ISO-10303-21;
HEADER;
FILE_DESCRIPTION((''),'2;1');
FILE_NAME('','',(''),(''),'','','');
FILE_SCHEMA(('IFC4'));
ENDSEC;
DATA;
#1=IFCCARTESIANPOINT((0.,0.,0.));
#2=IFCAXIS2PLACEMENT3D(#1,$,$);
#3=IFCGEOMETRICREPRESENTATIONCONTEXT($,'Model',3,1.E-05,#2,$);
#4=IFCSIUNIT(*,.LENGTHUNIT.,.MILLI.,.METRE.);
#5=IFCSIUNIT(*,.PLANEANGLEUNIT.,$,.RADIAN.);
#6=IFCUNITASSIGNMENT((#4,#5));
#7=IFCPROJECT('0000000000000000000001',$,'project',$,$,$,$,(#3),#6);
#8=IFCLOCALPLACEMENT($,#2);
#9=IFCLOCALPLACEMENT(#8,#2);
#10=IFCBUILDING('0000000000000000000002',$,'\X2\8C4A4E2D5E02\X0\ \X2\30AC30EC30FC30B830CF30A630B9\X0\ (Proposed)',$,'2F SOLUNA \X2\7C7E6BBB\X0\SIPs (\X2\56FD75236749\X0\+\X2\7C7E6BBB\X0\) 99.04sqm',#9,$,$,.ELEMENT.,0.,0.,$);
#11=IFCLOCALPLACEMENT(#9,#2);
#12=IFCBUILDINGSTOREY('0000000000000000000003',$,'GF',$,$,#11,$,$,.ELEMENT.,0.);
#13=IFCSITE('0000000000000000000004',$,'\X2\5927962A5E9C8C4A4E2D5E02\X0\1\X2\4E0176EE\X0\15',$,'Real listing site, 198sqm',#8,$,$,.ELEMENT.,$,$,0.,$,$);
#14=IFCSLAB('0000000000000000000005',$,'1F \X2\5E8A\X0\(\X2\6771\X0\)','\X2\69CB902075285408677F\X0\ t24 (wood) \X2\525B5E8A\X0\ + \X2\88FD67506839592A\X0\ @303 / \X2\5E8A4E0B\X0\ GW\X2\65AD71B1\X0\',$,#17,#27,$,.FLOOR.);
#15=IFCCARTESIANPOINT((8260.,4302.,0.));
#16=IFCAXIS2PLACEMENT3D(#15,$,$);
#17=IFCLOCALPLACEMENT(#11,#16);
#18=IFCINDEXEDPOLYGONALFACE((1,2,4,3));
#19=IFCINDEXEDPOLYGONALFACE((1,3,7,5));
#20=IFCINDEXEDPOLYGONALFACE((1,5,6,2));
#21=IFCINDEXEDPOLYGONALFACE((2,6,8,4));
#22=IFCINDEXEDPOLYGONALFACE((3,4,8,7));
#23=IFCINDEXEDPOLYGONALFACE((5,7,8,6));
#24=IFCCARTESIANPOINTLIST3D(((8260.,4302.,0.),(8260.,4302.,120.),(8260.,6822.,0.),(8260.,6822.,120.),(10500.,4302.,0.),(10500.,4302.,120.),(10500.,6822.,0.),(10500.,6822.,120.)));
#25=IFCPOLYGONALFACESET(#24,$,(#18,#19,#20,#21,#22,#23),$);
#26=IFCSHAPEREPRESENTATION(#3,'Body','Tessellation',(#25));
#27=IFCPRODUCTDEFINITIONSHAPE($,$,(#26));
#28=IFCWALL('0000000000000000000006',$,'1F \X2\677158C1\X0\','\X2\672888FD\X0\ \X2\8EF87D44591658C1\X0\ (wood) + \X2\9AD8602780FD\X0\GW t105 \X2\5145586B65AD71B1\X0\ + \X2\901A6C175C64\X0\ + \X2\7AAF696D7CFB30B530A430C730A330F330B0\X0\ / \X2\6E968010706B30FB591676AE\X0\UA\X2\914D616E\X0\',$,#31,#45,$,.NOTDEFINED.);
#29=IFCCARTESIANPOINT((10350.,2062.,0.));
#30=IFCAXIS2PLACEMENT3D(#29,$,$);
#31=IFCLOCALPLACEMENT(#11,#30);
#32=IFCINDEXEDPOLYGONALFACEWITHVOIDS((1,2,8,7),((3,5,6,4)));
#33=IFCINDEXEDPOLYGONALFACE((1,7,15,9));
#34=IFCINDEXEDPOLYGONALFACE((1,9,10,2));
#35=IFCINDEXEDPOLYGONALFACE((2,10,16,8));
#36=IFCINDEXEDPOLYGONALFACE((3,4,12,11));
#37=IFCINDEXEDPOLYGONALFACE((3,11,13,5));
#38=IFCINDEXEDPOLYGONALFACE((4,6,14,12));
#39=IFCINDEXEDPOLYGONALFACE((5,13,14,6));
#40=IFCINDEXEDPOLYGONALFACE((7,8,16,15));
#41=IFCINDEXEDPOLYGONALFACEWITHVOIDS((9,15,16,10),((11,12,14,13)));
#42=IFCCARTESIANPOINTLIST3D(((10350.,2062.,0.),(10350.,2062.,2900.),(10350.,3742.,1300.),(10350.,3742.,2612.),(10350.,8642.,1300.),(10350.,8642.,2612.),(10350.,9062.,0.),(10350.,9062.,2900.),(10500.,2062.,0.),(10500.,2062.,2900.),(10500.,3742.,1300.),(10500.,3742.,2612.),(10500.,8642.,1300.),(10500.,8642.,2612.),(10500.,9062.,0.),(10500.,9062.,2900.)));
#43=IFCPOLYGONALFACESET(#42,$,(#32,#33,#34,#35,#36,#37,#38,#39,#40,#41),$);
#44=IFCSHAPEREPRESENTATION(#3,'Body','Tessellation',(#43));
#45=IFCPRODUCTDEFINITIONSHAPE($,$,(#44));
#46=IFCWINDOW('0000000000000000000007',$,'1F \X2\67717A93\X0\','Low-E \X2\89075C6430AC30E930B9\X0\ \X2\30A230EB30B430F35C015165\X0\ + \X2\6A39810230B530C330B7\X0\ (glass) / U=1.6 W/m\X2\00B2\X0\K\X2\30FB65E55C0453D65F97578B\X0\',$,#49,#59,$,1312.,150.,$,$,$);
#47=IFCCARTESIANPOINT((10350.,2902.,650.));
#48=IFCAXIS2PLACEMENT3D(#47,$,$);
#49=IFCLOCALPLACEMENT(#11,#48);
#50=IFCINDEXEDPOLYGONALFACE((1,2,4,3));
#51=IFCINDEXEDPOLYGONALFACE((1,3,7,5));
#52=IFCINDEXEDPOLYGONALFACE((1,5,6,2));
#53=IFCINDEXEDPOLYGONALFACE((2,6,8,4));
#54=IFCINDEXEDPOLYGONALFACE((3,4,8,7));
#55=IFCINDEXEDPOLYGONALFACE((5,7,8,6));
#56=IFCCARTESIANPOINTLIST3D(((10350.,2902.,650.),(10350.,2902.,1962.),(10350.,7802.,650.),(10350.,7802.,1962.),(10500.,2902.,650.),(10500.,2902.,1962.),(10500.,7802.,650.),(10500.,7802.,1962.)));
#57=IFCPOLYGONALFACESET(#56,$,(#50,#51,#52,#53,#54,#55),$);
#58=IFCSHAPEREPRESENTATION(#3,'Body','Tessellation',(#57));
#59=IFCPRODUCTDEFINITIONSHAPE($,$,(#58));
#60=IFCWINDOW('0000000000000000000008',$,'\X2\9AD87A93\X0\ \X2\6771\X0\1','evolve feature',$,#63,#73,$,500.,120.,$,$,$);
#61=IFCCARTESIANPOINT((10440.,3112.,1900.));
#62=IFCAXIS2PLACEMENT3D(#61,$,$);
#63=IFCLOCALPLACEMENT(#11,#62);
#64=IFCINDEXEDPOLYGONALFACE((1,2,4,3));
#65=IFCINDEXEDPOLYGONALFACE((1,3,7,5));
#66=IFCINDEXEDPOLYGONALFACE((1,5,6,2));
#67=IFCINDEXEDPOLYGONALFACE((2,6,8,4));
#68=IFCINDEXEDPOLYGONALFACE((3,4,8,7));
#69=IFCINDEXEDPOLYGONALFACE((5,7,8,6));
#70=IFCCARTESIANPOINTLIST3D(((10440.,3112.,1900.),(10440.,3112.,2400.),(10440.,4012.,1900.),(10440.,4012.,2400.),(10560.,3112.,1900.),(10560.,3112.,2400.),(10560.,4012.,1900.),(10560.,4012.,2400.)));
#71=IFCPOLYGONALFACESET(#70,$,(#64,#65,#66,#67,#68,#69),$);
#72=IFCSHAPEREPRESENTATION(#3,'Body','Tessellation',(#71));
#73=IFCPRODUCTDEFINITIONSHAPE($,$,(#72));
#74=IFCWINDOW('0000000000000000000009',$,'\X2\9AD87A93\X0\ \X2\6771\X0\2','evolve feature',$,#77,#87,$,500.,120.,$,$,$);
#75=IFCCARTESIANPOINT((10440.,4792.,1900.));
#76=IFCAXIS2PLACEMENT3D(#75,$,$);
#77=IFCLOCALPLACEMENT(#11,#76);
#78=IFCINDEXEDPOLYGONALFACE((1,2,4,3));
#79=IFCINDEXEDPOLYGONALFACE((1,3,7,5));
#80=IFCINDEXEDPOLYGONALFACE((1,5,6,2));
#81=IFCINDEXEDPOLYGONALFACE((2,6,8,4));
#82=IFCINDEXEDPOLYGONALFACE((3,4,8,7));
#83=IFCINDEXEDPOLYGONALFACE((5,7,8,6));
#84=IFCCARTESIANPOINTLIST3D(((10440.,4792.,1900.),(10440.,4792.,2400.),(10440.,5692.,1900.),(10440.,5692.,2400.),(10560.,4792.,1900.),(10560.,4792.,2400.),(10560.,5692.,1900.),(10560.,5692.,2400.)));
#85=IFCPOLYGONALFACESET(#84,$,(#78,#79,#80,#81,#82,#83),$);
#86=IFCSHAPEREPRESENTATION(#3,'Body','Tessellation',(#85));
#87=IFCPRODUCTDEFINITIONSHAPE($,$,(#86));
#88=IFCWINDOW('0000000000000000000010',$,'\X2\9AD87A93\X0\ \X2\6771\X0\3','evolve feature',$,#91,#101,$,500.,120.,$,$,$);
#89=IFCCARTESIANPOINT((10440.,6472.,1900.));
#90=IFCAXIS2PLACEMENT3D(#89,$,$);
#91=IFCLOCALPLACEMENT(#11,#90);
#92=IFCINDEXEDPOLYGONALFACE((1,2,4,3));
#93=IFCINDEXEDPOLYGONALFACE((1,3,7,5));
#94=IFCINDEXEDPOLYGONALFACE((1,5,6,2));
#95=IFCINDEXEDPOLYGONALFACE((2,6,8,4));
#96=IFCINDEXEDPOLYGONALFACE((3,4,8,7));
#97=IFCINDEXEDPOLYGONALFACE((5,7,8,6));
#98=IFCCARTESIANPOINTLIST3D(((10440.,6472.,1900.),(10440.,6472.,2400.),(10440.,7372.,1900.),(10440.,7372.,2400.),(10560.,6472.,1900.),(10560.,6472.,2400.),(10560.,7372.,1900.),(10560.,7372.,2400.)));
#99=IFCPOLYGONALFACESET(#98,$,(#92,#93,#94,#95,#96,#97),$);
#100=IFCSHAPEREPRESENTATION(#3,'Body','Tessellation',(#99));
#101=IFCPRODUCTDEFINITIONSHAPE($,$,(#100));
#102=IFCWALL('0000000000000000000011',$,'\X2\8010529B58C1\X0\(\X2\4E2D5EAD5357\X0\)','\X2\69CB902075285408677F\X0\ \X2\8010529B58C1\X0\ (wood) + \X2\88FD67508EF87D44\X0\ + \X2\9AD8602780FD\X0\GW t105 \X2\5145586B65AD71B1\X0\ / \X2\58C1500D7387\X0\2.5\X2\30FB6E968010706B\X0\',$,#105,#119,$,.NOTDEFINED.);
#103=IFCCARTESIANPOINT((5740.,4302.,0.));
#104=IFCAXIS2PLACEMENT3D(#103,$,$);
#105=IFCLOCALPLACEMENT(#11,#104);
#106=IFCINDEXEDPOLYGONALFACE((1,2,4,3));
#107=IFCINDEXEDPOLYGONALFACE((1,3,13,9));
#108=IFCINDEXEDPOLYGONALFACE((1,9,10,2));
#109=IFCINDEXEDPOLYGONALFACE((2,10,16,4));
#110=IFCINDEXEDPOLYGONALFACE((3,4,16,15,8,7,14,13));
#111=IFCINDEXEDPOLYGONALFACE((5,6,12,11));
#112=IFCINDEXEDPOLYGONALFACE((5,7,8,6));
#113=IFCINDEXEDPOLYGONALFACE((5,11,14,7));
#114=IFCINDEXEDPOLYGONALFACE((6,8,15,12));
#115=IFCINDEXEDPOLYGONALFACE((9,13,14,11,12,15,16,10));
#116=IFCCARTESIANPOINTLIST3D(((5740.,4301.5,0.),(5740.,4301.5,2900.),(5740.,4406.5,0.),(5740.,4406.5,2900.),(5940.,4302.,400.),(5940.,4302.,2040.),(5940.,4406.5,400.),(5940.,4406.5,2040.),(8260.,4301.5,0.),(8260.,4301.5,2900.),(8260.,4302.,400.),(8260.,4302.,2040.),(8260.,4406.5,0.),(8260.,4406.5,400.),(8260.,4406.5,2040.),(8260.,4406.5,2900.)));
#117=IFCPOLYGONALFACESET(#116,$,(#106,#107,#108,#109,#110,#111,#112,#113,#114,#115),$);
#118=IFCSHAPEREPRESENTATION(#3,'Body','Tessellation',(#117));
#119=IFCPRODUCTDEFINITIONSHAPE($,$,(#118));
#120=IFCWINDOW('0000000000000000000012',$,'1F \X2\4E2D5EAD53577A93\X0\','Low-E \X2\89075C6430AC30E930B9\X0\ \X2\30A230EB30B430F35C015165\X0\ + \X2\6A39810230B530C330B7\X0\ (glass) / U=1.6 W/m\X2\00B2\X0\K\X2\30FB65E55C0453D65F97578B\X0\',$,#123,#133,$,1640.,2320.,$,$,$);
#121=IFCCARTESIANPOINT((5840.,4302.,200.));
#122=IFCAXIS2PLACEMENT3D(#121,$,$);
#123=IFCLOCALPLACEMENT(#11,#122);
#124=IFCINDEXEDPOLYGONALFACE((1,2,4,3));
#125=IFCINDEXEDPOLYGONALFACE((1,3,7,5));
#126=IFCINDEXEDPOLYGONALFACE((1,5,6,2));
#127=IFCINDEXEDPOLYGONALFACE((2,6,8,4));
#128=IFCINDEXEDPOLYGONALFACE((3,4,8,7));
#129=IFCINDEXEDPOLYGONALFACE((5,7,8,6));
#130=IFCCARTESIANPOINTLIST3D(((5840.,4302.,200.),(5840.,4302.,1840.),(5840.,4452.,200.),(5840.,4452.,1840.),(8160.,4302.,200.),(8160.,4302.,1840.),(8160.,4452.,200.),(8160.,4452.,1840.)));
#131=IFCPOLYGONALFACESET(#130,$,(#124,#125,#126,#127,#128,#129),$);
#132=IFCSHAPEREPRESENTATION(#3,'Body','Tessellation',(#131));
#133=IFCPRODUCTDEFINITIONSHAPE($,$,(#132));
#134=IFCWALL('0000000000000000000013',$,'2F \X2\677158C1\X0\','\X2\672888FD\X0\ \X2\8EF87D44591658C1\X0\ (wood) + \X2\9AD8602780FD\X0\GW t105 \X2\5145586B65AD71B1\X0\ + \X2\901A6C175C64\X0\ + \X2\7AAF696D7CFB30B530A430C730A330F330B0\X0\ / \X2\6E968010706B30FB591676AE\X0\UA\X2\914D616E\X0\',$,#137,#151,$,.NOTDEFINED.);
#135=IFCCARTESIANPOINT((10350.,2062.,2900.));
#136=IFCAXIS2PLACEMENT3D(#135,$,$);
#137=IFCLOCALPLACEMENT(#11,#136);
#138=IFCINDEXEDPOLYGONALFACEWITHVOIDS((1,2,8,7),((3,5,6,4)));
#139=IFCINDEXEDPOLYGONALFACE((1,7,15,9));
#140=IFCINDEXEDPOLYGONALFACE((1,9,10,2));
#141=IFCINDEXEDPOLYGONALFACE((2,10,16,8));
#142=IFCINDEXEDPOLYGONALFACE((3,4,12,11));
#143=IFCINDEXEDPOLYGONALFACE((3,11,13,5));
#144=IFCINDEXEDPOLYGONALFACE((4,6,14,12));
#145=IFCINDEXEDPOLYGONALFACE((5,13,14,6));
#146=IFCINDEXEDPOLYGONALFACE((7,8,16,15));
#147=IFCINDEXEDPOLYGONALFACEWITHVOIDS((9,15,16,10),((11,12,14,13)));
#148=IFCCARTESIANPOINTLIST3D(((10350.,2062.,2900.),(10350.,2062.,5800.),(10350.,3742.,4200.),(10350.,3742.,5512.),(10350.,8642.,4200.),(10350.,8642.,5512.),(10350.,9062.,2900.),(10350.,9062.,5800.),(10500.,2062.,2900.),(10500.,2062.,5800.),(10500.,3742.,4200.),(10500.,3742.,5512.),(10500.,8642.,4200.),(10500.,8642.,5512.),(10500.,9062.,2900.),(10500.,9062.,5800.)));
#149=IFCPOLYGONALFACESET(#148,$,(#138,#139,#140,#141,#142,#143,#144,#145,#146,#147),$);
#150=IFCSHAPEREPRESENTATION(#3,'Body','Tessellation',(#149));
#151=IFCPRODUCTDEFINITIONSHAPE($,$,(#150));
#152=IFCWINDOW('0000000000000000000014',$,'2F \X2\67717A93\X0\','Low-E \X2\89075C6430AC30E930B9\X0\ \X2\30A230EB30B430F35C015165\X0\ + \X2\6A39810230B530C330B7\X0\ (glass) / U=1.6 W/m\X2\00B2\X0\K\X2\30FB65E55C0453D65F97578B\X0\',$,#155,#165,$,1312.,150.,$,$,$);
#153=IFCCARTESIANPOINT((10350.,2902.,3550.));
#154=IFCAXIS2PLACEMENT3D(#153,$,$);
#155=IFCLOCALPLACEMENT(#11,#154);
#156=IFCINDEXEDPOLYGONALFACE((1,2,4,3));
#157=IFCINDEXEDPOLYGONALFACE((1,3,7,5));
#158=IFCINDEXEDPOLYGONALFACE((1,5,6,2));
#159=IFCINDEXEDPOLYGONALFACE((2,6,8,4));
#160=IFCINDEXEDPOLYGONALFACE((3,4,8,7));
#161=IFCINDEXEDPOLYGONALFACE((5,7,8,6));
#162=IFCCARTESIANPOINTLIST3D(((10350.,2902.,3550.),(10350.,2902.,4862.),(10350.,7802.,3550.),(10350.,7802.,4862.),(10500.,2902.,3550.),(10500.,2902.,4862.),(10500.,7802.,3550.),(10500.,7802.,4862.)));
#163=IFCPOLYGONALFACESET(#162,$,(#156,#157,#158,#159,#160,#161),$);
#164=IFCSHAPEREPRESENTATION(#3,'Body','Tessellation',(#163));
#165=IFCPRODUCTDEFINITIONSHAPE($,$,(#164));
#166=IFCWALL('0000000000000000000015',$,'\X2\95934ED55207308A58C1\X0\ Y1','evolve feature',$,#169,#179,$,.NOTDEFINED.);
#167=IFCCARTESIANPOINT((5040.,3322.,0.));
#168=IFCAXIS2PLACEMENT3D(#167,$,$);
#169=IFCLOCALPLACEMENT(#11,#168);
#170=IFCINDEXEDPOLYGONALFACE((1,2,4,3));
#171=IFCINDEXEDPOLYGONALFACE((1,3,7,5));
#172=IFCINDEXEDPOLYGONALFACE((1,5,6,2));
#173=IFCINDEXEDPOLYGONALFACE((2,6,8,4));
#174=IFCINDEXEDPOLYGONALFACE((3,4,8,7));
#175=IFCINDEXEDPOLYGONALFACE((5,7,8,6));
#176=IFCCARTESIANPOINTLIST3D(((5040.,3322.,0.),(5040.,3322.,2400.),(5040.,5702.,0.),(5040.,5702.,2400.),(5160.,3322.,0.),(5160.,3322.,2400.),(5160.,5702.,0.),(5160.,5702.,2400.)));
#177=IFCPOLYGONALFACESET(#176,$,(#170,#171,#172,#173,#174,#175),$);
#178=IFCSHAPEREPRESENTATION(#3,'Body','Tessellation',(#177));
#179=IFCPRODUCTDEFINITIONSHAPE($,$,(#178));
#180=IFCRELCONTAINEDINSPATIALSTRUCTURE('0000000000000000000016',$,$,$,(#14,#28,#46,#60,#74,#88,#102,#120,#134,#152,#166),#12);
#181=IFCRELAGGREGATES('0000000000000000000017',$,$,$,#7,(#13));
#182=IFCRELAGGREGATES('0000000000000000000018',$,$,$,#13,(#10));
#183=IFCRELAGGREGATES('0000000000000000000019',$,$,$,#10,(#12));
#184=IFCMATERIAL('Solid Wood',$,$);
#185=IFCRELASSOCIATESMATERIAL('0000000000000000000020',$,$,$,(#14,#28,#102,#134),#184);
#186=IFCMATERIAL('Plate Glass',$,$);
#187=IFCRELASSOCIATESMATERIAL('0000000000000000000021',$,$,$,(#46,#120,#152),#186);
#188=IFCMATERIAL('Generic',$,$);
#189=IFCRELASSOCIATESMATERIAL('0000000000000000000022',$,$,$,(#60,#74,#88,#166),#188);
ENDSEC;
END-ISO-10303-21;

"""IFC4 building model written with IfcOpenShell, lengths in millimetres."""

from ifc_helpers import new_model, si_unit, frame, frame_2d, origin, place, context, project, spatial, rectangle, extrude, material, element, fill, save


model = new_model("IFC4")

# Units and contexts
model_context = context("Model", 3, precision=1e-05, world=origin())
ifc_project = project(units=[si_unit("LENGTHUNIT", "METRE", prefix="MILLI"), si_unit("PLANEANGLEUNIT", "RADIAN")], contexts=[model_context])

# Site, building, storey
site_placement = place(None, origin())
site = spatial("IfcSite", under=ifc_project, at=site_placement, Name="大阪府豊中市1丁目15", ObjectType="Real listing site, 198sqm", CompositionType="ELEMENT", RefElevation=0.0)
building_placement = place(site_placement, origin())
building = spatial("IfcBuilding", under=site, at=building_placement, Name="豊中市 ガレージハウス (Proposed)", ObjectType="2F SOLUNA 籾殻SIPs (国産杉+籾殻) 99.04sqm", CompositionType="ELEMENT", ElevationOfRefHeight=0.0, ElevationOfTerrain=0.0)
storey_placement = place(building_placement, origin())
storey = spatial("IfcBuildingStorey", under=building, at=storey_placement, Name="GF", CompositionType="ELEMENT", Elevation=0.0)

# Slab
ifc_material_1 = material(Name="Solid Wood")
slab_placement = place(storey_placement, frame((8260.0, 4302.0, 0.0)))
element("IfcSlab", 1, at=slab_placement, inside=storey, material=ifc_material_1, Name="1F 床(東)", Description="構造用合板 t24 (wood) 剛床 + 製材根太 @303 / 床下 GW断熱", PredefinedType="FLOOR", context=model_context, shape_type="SweptSolid", body=[
    extrude(rectangle(XDim=2240.0, YDim=2520.0, at=frame_2d((1120.0, 1260.0))), frame((8260.0, 4302.0, 0.0)), (0.0, 0.0, 1.0), 120.0),
])

# Wall, openings, windows
wall_1_placement = place(storey_placement, frame((10350.0, 2062.0, 0.0)))
wall_1 = element("IfcWall", 2, at=wall_1_placement, inside=storey, material=ifc_material_1, Name="1F 東壁", Description="木製 軸組外壁 (wood) + 高性能GW t105 充填断熱 + 通気層 + 窯業系サイディング / 準耐火・外皮UA配慮", PredefinedType="NOTDEFINED", context=model_context, shape_type="SweptSolid", body=[
    extrude(rectangle(XDim=150.0, YDim=7000.0, at=frame_2d((75.0, 3500.0))), frame((10350.0, 2062.0, 0.0)), (0.0, 0.0, 1.0), 2900.0),
])
opening_1_placement = place(storey_placement, frame((10350.0, 2902.0, 650.0)))
opening_1 = element("IfcOpeningElement", 3, at=opening_1_placement, cuts=wall_1, PredefinedType="NOTDEFINED", context=model_context, shape_type="SweptSolid", body=[
    extrude(rectangle(XDim=150.0, YDim=4900.0, at=frame_2d((75.0, 2450.0))), frame((10350.0, 2902.0, 650.0)), (0.0, 0.0, 1.0), 1312.0),
])
opening_2_placement = place(storey_placement, frame((10440.0, 3112.0, 1900.0)))
opening_2 = element("IfcOpeningElement", 4, at=opening_2_placement, cuts=wall_1, PredefinedType="NOTDEFINED", context=model_context, shape_type="SweptSolid", body=[
    extrude(rectangle(XDim=120.0, YDim=900.0, at=frame_2d((60.0, 450.0))), frame((10440.0, 3112.0, 1900.0)), (0.0, 0.0, 1.0), 500.0),
])
opening_3_placement = place(storey_placement, frame((10440.0, 4792.0, 1900.0)))
opening_3 = element("IfcOpeningElement", 5, at=opening_3_placement, cuts=wall_1, PredefinedType="NOTDEFINED", context=model_context, shape_type="SweptSolid", body=[
    extrude(rectangle(XDim=120.0, YDim=900.0, at=frame_2d((60.0, 450.0))), frame((10440.0, 4792.0, 1900.0)), (0.0, 0.0, 1.0), 500.0),
])
opening_4_placement = place(storey_placement, frame((10440.0, 6472.0, 1900.0)))
opening_4 = element("IfcOpeningElement", 6, at=opening_4_placement, cuts=wall_1, PredefinedType="NOTDEFINED", context=model_context, shape_type="SweptSolid", body=[
    extrude(rectangle(XDim=120.0, YDim=900.0, at=frame_2d((60.0, 450.0))), frame((10440.0, 6472.0, 1900.0)), (0.0, 0.0, 1.0), 500.0),
])
ifc_material_2 = material(Name="Plate Glass")
window_1_placement = place(storey_placement, frame((10350.0, 2902.0, 650.0)))
window_1 = element("IfcWindow", 7, at=window_1_placement, inside=storey, material=ifc_material_2, Name="1F 東窓", Description="Low-E 複層ガラス アルゴン封入 + 樹脂サッシ (glass) / U=1.6 W/m²K・日射取得型", OverallHeight=1312.0, OverallWidth=150.0, context=model_context, shape_type="SweptSolid", body=[
    extrude(rectangle(XDim=150.0, YDim=4900.0, at=frame_2d((75.0, 2450.0))), frame((10350.0, 2902.0, 650.0)), (0.0, 0.0, 1.0), 1312.0),
])
fill(opening_1, window_1)
ifc_material_3 = material(Name="Generic")
window_2_placement = place(storey_placement, frame((10440.0, 3112.0, 1900.0)))
window_2 = element("IfcWindow", 8, at=window_2_placement, inside=storey, material=ifc_material_3, Name="高窓 東1", Description="evolve feature", OverallHeight=500.0, OverallWidth=120.0, context=model_context, shape_type="SweptSolid", body=[
    extrude(rectangle(XDim=120.0, YDim=900.0, at=frame_2d((60.0, 450.0))), frame((10440.0, 3112.0, 1900.0)), (0.0, 0.0, 1.0), 500.0),
])
fill(opening_2, window_2)
window_3_placement = place(storey_placement, frame((10440.0, 4792.0, 1900.0)))
window_3 = element("IfcWindow", 9, at=window_3_placement, inside=storey, material=ifc_material_3, Name="高窓 東2", Description="evolve feature", OverallHeight=500.0, OverallWidth=120.0, context=model_context, shape_type="SweptSolid", body=[
    extrude(rectangle(XDim=120.0, YDim=900.0, at=frame_2d((60.0, 450.0))), frame((10440.0, 4792.0, 1900.0)), (0.0, 0.0, 1.0), 500.0),
])
fill(opening_3, window_3)
window_4_placement = place(storey_placement, frame((10440.0, 6472.0, 1900.0)))
window_4 = element("IfcWindow", 10, at=window_4_placement, inside=storey, material=ifc_material_3, Name="高窓 東3", Description="evolve feature", OverallHeight=500.0, OverallWidth=120.0, context=model_context, shape_type="SweptSolid", body=[
    extrude(rectangle(XDim=120.0, YDim=900.0, at=frame_2d((60.0, 450.0))), frame((10440.0, 6472.0, 1900.0)), (0.0, 0.0, 1.0), 500.0),
])
fill(opening_4, window_4)

# Wall, opening, window
wall_2_placement = place(storey_placement, frame((5740.0, 4302.0, 0.0)))
wall_2 = element("IfcWall", 11, at=wall_2_placement, inside=storey, material=ifc_material_1, Name="耐力壁(中庭南)", Description="構造用合板 耐力壁 (wood) + 製材軸組 + 高性能GW t105 充填断熱 / 壁倍率2.5・準耐火", PredefinedType="NOTDEFINED", context=model_context, shape_type="SweptSolid", body=[
    extrude(rectangle(XDim=2520.0, YDim=105.0, at=frame_2d((1260.0, 52.0))), frame((5740.0, 4302.0, 0.0)), (0.0, 0.0, 1.0), 2900.0),
])
opening_5_placement = place(storey_placement, frame((5840.0, 4302.0, 200.0)))
opening_5 = element("IfcOpeningElement", 12, at=opening_5_placement, cuts=wall_2, PredefinedType="NOTDEFINED", context=model_context, shape_type="SweptSolid", body=[
    extrude(rectangle(XDim=2320.0, YDim=150.0, at=frame_2d((1160.0, 75.0))), frame((5840.0, 4302.0, 200.0)), (0.0, 0.0, 1.0), 1640.0),
])
window_5_placement = place(storey_placement, frame((5840.0, 4302.0, 200.0)))
window_5 = element("IfcWindow", 13, at=window_5_placement, inside=storey, material=ifc_material_2, Name="1F 中庭南窓", Description="Low-E 複層ガラス アルゴン封入 + 樹脂サッシ (glass) / U=1.6 W/m²K・日射取得型", OverallHeight=1640.0, OverallWidth=2320.0, context=model_context, shape_type="SweptSolid", body=[
    extrude(rectangle(XDim=2320.0, YDim=150.0, at=frame_2d((1160.0, 75.0))), frame((5840.0, 4302.0, 200.0)), (0.0, 0.0, 1.0), 1640.0),
])
fill(opening_5, window_5)

# Wall, opening, window
wall_3_placement = place(storey_placement, frame((10350.0, 2062.0, 2900.0)))
wall_3 = element("IfcWall", 14, at=wall_3_placement, inside=storey, material=ifc_material_1, Name="2F 東壁", Description="木製 軸組外壁 (wood) + 高性能GW t105 充填断熱 + 通気層 + 窯業系サイディング / 準耐火・外皮UA配慮", PredefinedType="NOTDEFINED", context=model_context, shape_type="SweptSolid", body=[
    extrude(rectangle(XDim=150.0, YDim=7000.0, at=frame_2d((75.0, 3500.0))), frame((10350.0, 2062.0, 2900.0)), (0.0, 0.0, 1.0), 2900.0),
])
opening_6_placement = place(storey_placement, frame((10350.0, 2902.0, 3550.0)))
opening_6 = element("IfcOpeningElement", 15, at=opening_6_placement, cuts=wall_3, PredefinedType="NOTDEFINED", context=model_context, shape_type="SweptSolid", body=[
    extrude(rectangle(XDim=150.0, YDim=4900.0, at=frame_2d((75.0, 2450.0))), frame((10350.0, 2902.0, 3550.0)), (0.0, 0.0, 1.0), 1312.0),
])
window_6_placement = place(storey_placement, frame((10350.0, 2902.0, 3550.0)))
window_6 = element("IfcWindow", 16, at=window_6_placement, inside=storey, material=ifc_material_2, Name="2F 東窓", Description="Low-E 複層ガラス アルゴン封入 + 樹脂サッシ (glass) / U=1.6 W/m²K・日射取得型", OverallHeight=1312.0, OverallWidth=150.0, context=model_context, shape_type="SweptSolid", body=[
    extrude(rectangle(XDim=150.0, YDim=4900.0, at=frame_2d((75.0, 2450.0))), frame((10350.0, 2902.0, 3550.0)), (0.0, 0.0, 1.0), 1312.0),
])
fill(opening_6, window_6)

# Wall
wall_4_placement = place(storey_placement, frame((5040.0, 3322.0, 0.0)))
element("IfcWall", 17, at=wall_4_placement, inside=storey, material=ifc_material_3, Name="間仕切り壁 Y1", Description="evolve feature", PredefinedType="NOTDEFINED", context=model_context, shape_type="SweptSolid", body=[
    extrude(rectangle(XDim=120.0, YDim=2380.0, at=frame_2d((60.0, 1190.0))), frame((5040.0, 3322.0, 0.0)), (0.0, 0.0, 1.0), 2400.0),
])

save(model, "model.ifc")
